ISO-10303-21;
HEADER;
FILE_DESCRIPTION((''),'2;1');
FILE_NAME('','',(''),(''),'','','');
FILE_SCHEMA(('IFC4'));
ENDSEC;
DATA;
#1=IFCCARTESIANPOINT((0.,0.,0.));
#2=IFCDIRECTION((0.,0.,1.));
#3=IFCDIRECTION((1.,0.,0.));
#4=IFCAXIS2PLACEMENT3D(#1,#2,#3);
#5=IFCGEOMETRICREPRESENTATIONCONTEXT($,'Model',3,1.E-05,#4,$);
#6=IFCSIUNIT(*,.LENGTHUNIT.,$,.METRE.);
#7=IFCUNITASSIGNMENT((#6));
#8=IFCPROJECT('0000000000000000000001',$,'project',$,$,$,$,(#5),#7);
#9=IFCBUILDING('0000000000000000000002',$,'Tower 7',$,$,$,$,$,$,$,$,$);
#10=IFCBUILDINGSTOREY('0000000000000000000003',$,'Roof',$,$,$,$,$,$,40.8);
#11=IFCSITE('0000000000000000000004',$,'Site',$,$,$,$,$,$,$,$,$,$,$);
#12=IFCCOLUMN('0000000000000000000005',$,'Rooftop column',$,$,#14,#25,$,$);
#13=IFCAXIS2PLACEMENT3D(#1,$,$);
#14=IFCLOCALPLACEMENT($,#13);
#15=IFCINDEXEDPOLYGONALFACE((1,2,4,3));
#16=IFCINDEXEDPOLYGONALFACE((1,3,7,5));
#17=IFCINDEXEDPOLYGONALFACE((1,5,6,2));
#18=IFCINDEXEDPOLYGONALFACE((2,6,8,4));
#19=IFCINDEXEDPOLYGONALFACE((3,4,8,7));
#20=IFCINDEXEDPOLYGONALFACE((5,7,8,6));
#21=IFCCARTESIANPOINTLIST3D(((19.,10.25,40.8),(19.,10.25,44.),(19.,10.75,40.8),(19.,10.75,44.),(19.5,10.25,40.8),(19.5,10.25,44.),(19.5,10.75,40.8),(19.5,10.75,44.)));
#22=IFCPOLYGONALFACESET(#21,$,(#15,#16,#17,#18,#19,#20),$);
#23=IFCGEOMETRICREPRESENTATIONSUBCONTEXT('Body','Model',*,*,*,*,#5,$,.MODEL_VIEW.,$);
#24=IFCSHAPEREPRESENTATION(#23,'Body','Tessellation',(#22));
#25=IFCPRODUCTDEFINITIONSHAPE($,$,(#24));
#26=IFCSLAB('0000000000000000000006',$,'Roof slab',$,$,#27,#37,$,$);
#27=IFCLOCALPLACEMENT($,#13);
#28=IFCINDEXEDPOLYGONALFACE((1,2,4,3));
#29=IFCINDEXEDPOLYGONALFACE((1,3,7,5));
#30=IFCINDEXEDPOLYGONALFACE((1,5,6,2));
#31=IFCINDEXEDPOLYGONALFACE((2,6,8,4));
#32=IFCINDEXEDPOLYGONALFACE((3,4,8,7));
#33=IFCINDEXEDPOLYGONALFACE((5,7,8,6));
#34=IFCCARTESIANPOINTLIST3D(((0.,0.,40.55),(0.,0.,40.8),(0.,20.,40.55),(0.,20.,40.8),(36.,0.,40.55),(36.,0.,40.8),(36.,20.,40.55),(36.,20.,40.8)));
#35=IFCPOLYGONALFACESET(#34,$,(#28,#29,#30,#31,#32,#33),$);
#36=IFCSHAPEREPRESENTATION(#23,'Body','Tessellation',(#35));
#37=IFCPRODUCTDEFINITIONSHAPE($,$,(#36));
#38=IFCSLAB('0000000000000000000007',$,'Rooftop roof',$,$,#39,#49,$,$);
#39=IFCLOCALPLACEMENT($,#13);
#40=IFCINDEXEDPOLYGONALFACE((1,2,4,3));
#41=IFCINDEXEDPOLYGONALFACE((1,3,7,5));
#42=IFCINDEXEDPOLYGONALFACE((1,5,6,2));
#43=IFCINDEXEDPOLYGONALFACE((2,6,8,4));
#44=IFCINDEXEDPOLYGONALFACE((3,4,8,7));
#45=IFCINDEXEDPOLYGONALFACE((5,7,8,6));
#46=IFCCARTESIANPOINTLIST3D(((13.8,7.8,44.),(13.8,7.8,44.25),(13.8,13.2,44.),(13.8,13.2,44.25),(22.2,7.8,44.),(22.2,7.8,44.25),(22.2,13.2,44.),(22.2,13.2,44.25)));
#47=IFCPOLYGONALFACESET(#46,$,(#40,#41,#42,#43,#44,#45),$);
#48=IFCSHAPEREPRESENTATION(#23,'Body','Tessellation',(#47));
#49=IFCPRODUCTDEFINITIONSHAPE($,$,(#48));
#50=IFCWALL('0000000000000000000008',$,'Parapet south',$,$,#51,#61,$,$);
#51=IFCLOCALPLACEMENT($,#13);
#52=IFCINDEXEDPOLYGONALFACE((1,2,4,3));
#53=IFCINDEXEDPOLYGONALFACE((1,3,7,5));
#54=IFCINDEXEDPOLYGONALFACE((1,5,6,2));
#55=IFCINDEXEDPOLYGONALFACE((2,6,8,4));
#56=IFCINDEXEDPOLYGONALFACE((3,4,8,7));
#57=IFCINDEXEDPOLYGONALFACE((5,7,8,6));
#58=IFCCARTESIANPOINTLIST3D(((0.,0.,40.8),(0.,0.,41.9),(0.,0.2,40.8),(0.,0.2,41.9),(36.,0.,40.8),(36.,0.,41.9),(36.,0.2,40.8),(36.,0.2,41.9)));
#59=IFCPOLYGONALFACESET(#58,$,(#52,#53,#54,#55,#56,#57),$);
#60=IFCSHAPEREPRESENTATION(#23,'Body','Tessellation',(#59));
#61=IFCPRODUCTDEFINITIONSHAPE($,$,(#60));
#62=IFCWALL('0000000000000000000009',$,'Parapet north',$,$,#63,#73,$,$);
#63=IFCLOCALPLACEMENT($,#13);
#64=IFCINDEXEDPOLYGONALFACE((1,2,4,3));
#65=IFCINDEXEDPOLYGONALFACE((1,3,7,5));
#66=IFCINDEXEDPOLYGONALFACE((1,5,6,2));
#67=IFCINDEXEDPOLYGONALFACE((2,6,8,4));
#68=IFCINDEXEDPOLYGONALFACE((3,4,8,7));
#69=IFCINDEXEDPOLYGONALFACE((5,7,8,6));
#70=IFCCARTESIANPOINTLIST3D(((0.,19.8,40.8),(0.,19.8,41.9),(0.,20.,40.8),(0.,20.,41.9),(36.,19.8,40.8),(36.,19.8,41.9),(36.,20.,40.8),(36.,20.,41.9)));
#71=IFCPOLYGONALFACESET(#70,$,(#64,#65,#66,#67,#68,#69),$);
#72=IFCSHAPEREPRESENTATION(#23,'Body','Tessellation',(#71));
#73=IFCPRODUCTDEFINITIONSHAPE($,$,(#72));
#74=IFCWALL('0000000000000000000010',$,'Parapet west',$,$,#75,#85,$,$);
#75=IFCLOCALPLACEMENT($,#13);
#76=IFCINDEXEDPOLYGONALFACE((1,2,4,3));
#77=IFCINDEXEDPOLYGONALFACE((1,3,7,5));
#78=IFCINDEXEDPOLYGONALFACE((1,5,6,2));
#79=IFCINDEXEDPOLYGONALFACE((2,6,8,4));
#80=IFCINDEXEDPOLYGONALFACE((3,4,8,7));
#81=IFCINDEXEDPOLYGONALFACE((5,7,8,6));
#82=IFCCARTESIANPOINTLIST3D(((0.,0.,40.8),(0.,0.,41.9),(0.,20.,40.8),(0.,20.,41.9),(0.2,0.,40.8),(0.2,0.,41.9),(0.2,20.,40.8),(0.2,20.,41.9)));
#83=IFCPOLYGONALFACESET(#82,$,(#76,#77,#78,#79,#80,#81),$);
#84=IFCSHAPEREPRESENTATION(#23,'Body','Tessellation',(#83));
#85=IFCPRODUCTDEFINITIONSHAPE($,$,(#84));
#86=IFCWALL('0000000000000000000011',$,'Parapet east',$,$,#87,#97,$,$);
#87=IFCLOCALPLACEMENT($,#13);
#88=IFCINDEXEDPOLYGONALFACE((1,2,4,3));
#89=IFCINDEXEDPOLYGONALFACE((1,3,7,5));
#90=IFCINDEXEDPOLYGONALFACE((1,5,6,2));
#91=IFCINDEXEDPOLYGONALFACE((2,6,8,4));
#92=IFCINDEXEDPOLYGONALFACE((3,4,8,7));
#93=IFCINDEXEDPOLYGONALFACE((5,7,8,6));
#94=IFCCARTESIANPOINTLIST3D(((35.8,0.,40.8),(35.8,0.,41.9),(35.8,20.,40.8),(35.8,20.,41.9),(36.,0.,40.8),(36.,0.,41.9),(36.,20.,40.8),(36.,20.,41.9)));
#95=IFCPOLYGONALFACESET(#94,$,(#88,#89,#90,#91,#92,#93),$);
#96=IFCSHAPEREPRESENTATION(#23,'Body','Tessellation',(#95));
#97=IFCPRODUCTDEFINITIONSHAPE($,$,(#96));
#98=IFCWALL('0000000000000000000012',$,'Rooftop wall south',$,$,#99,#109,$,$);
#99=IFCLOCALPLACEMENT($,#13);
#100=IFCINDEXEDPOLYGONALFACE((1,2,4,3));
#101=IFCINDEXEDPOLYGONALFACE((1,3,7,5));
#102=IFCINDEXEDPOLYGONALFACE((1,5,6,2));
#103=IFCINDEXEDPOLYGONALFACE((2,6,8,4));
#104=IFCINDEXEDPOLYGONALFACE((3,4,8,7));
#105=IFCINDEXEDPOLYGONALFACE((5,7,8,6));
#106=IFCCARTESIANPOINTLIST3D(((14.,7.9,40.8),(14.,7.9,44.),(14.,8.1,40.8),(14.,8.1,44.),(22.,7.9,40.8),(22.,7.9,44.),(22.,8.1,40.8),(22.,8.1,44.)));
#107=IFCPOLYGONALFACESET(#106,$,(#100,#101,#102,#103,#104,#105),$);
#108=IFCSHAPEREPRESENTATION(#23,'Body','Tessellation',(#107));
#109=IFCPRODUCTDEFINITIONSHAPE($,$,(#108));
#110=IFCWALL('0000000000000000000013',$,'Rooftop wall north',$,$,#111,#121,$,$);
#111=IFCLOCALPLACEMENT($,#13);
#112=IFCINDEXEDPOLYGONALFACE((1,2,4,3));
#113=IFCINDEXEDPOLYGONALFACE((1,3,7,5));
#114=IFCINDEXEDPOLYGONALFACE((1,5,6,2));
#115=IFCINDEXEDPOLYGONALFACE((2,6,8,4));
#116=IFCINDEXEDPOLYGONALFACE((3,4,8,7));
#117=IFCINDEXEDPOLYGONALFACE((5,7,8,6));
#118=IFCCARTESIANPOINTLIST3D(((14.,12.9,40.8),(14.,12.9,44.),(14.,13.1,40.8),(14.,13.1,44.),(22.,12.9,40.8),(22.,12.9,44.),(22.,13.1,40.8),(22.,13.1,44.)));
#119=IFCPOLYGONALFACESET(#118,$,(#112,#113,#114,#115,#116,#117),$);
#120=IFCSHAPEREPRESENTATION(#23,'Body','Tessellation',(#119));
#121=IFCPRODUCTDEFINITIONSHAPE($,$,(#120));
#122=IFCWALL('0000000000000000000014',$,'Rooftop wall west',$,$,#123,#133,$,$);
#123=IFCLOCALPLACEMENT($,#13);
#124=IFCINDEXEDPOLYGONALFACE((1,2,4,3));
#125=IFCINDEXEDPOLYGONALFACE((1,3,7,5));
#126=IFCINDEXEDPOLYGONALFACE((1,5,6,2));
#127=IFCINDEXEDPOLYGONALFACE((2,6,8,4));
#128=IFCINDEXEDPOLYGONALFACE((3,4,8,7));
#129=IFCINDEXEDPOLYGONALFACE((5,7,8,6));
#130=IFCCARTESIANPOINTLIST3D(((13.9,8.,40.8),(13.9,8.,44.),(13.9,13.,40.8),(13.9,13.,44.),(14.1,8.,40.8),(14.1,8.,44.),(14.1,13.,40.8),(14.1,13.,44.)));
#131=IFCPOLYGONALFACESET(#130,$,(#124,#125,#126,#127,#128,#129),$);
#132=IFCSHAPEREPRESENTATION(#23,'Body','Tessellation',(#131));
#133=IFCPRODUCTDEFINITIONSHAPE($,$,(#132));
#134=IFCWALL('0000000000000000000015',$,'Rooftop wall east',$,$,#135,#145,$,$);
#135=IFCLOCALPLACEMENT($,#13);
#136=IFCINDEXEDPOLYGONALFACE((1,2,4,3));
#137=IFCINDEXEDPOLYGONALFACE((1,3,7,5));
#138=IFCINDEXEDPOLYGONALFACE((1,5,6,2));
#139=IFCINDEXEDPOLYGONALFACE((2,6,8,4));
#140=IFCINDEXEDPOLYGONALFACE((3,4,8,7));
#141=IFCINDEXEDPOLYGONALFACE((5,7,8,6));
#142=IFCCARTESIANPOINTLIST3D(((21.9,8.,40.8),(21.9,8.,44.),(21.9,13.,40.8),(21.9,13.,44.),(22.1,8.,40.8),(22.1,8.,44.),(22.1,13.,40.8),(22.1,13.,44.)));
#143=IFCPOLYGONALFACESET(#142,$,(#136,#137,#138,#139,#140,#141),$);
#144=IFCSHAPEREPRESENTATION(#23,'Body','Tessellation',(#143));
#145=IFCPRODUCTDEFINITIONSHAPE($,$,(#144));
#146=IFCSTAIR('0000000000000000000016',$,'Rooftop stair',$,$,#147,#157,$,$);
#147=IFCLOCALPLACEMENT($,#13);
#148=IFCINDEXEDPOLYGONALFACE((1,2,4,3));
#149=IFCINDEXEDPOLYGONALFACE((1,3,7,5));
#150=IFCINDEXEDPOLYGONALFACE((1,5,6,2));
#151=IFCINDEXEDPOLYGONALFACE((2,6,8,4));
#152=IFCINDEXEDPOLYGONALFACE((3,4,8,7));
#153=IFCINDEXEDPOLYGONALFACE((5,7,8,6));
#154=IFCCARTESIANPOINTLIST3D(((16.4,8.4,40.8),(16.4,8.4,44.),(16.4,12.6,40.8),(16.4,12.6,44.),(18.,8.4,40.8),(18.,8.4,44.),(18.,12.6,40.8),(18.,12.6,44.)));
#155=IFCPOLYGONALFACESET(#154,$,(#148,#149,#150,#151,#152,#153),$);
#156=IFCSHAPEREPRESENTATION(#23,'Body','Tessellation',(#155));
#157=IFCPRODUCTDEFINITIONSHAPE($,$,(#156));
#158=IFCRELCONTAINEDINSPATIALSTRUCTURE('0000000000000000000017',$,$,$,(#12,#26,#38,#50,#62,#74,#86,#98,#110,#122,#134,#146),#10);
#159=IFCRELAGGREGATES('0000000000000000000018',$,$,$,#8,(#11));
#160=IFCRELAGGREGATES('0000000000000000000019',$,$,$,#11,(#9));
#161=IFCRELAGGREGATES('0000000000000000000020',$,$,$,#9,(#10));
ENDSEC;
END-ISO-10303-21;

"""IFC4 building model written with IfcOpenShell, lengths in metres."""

from ifc_helpers import new_model, si_unit, frame, origin, origin_with_axes, origin_2d, place, context, subcontext, project, spatial, rectangle, extrude, element, save


model = new_model("IFC4")

# Units and contexts
model_context = context("Model", 3, precision=1e-05, world=origin_with_axes())
body_context = subcontext(model_context, "Body", "Model", "MODEL_VIEW")
ifc_project = project(units=[si_unit("LENGTHUNIT", "METRE")], contexts=[model_context])

# Site, building, storey
site = spatial("IfcSite", under=ifc_project, Name="Site")
building = spatial("IfcBuilding", under=site, Name="Tower 7")
storey = spatial("IfcBuildingStorey", under=building, Name="Roof", Elevation=40.8)

# Column
column_placement = place(None, frame((19.25, 10.5, 40.8), z_axis=(0.0, 0.0, 1.0), x_axis=(1.0, 0.0, 0.0)))
element("IfcColumn", 1, at=column_placement, inside=storey, Name="Rooftop column", context=body_context, shape_type="SweptSolid", body=[
    extrude(rectangle(XDim=0.5, YDim=0.5, at=origin_2d()), origin(), (0.0, 0.0, 1.0), 3.2),
])

# Slabs
slab_1_placement = place(None, frame((18.0, 10.0, 40.55), z_axis=(0.0, 0.0, 1.0), x_axis=(1.0, 0.0, 0.0)))
element("IfcSlab", 2, at=slab_1_placement, inside=storey, Name="Roof slab", context=body_context, shape_type="SweptSolid", body=[
    extrude(rectangle(XDim=36.0, YDim=20.0, at=origin_2d()), origin(), (0.0, 0.0, 1.0), 0.25),
])
slab_2_placement = place(None, frame((18.0, 10.5, 44.0), z_axis=(0.0, 0.0, 1.0), x_axis=(1.0, 0.0, 0.0)))
element("IfcSlab", 3, at=slab_2_placement, inside=storey, Name="Rooftop roof", context=body_context, shape_type="SweptSolid", body=[
    extrude(rectangle(XDim=8.4, YDim=5.4, at=origin_2d()), origin(), (0.0, 0.0, 1.0), 0.25),
])

# Walls
wall_1_placement = place(None, frame((18.0, 0.1, 40.8), z_axis=(0.0, 0.0, 1.0), x_axis=(1.0, 0.0, 0.0)))
element("IfcWall", 4, at=wall_1_placement, inside=storey, Name="Parapet south", context=body_context, shape_type="SweptSolid", body=[
    extrude(rectangle(XDim=36.0, YDim=0.2, at=origin_2d()), origin(), (0.0, 0.0, 1.0), 1.1),
])
wall_2_placement = place(None, frame((18.0, 19.9, 40.8), z_axis=(0.0, 0.0, 1.0), x_axis=(1.0, 0.0, 0.0)))
element("IfcWall", 5, at=wall_2_placement, inside=storey, Name="Parapet north", context=body_context, shape_type="SweptSolid", body=[
    extrude(rectangle(XDim=36.0, YDim=0.2, at=origin_2d()), origin(), (0.0, 0.0, 1.0), 1.1),
])
wall_3_placement = place(None, frame((0.1, 10.0, 40.8), z_axis=(0.0, 0.0, 1.0), x_axis=(1.0, 0.0, 0.0)))
element("IfcWall", 6, at=wall_3_placement, inside=storey, Name="Parapet west", context=body_context, shape_type="SweptSolid", body=[
    extrude(rectangle(XDim=0.2, YDim=20.0, at=origin_2d()), origin(), (0.0, 0.0, 1.0), 1.1),
])
wall_4_placement = place(None, frame((35.9, 10.0, 40.8), z_axis=(0.0, 0.0, 1.0), x_axis=(1.0, 0.0, 0.0)))
element("IfcWall", 7, at=wall_4_placement, inside=storey, Name="Parapet east", context=body_context, shape_type="SweptSolid", body=[
    extrude(rectangle(XDim=0.2, YDim=20.0, at=origin_2d()), origin(), (0.0, 0.0, 1.0), 1.1),
])
for number, where, z_axis, x_axis, name in (
    (8, (18.0, 8.0, 40.8), (0.0, 0.0, 1.0), (1.0, 0.0, 0.0), "Rooftop wall south"),
    (9, (18.0, 13.0, 40.8), (0.0, 0.0, 1.0), (1.0, 0.0, 0.0), "Rooftop wall north"),
):
    element("IfcWall", number, at=place(None, frame(where, z_axis=z_axis, x_axis=x_axis)), inside=storey, Name=name, context=body_context, shape_type="SweptSolid", body=[
        extrude(rectangle(XDim=8.0, YDim=0.2, at=origin_2d()), origin(), (0.0, 0.0, 1.0), 3.2),
    ])
wall_5_placement = place(None, frame((14.0, 10.5, 40.8), z_axis=(0.0, 0.0, 1.0), x_axis=(1.0, 0.0, 0.0)))
element("IfcWall", 10, at=wall_5_placement, inside=storey, Name="Rooftop wall west", context=body_context, shape_type="SweptSolid", body=[
    extrude(rectangle(XDim=0.2, YDim=5.0, at=origin_2d()), origin(), (0.0, 0.0, 1.0), 3.2),
])
wall_6_placement = place(None, frame((22.0, 10.5, 40.8), z_axis=(0.0, 0.0, 1.0), x_axis=(1.0, 0.0, 0.0)))
element("IfcWall", 11, at=wall_6_placement, inside=storey, Name="Rooftop wall east", context=body_context, shape_type="SweptSolid", body=[
    extrude(rectangle(XDim=0.2, YDim=5.0, at=origin_2d()), origin(), (0.0, 0.0, 1.0), 3.2),
])

# Stair
stair_placement = place(None, frame((17.2, 10.5, 40.8), z_axis=(0.0, 0.0, 1.0), x_axis=(1.0, 0.0, 0.0)))
element("IfcStair", 12, at=stair_placement, inside=storey, Name="Rooftop stair", context=body_context, shape_type="SweptSolid", body=[
    extrude(rectangle(XDim=1.6, YDim=4.2, at=origin_2d()), origin(), (0.0, 0.0, 1.0), 3.2),
])

save(model, "model.ifc")
